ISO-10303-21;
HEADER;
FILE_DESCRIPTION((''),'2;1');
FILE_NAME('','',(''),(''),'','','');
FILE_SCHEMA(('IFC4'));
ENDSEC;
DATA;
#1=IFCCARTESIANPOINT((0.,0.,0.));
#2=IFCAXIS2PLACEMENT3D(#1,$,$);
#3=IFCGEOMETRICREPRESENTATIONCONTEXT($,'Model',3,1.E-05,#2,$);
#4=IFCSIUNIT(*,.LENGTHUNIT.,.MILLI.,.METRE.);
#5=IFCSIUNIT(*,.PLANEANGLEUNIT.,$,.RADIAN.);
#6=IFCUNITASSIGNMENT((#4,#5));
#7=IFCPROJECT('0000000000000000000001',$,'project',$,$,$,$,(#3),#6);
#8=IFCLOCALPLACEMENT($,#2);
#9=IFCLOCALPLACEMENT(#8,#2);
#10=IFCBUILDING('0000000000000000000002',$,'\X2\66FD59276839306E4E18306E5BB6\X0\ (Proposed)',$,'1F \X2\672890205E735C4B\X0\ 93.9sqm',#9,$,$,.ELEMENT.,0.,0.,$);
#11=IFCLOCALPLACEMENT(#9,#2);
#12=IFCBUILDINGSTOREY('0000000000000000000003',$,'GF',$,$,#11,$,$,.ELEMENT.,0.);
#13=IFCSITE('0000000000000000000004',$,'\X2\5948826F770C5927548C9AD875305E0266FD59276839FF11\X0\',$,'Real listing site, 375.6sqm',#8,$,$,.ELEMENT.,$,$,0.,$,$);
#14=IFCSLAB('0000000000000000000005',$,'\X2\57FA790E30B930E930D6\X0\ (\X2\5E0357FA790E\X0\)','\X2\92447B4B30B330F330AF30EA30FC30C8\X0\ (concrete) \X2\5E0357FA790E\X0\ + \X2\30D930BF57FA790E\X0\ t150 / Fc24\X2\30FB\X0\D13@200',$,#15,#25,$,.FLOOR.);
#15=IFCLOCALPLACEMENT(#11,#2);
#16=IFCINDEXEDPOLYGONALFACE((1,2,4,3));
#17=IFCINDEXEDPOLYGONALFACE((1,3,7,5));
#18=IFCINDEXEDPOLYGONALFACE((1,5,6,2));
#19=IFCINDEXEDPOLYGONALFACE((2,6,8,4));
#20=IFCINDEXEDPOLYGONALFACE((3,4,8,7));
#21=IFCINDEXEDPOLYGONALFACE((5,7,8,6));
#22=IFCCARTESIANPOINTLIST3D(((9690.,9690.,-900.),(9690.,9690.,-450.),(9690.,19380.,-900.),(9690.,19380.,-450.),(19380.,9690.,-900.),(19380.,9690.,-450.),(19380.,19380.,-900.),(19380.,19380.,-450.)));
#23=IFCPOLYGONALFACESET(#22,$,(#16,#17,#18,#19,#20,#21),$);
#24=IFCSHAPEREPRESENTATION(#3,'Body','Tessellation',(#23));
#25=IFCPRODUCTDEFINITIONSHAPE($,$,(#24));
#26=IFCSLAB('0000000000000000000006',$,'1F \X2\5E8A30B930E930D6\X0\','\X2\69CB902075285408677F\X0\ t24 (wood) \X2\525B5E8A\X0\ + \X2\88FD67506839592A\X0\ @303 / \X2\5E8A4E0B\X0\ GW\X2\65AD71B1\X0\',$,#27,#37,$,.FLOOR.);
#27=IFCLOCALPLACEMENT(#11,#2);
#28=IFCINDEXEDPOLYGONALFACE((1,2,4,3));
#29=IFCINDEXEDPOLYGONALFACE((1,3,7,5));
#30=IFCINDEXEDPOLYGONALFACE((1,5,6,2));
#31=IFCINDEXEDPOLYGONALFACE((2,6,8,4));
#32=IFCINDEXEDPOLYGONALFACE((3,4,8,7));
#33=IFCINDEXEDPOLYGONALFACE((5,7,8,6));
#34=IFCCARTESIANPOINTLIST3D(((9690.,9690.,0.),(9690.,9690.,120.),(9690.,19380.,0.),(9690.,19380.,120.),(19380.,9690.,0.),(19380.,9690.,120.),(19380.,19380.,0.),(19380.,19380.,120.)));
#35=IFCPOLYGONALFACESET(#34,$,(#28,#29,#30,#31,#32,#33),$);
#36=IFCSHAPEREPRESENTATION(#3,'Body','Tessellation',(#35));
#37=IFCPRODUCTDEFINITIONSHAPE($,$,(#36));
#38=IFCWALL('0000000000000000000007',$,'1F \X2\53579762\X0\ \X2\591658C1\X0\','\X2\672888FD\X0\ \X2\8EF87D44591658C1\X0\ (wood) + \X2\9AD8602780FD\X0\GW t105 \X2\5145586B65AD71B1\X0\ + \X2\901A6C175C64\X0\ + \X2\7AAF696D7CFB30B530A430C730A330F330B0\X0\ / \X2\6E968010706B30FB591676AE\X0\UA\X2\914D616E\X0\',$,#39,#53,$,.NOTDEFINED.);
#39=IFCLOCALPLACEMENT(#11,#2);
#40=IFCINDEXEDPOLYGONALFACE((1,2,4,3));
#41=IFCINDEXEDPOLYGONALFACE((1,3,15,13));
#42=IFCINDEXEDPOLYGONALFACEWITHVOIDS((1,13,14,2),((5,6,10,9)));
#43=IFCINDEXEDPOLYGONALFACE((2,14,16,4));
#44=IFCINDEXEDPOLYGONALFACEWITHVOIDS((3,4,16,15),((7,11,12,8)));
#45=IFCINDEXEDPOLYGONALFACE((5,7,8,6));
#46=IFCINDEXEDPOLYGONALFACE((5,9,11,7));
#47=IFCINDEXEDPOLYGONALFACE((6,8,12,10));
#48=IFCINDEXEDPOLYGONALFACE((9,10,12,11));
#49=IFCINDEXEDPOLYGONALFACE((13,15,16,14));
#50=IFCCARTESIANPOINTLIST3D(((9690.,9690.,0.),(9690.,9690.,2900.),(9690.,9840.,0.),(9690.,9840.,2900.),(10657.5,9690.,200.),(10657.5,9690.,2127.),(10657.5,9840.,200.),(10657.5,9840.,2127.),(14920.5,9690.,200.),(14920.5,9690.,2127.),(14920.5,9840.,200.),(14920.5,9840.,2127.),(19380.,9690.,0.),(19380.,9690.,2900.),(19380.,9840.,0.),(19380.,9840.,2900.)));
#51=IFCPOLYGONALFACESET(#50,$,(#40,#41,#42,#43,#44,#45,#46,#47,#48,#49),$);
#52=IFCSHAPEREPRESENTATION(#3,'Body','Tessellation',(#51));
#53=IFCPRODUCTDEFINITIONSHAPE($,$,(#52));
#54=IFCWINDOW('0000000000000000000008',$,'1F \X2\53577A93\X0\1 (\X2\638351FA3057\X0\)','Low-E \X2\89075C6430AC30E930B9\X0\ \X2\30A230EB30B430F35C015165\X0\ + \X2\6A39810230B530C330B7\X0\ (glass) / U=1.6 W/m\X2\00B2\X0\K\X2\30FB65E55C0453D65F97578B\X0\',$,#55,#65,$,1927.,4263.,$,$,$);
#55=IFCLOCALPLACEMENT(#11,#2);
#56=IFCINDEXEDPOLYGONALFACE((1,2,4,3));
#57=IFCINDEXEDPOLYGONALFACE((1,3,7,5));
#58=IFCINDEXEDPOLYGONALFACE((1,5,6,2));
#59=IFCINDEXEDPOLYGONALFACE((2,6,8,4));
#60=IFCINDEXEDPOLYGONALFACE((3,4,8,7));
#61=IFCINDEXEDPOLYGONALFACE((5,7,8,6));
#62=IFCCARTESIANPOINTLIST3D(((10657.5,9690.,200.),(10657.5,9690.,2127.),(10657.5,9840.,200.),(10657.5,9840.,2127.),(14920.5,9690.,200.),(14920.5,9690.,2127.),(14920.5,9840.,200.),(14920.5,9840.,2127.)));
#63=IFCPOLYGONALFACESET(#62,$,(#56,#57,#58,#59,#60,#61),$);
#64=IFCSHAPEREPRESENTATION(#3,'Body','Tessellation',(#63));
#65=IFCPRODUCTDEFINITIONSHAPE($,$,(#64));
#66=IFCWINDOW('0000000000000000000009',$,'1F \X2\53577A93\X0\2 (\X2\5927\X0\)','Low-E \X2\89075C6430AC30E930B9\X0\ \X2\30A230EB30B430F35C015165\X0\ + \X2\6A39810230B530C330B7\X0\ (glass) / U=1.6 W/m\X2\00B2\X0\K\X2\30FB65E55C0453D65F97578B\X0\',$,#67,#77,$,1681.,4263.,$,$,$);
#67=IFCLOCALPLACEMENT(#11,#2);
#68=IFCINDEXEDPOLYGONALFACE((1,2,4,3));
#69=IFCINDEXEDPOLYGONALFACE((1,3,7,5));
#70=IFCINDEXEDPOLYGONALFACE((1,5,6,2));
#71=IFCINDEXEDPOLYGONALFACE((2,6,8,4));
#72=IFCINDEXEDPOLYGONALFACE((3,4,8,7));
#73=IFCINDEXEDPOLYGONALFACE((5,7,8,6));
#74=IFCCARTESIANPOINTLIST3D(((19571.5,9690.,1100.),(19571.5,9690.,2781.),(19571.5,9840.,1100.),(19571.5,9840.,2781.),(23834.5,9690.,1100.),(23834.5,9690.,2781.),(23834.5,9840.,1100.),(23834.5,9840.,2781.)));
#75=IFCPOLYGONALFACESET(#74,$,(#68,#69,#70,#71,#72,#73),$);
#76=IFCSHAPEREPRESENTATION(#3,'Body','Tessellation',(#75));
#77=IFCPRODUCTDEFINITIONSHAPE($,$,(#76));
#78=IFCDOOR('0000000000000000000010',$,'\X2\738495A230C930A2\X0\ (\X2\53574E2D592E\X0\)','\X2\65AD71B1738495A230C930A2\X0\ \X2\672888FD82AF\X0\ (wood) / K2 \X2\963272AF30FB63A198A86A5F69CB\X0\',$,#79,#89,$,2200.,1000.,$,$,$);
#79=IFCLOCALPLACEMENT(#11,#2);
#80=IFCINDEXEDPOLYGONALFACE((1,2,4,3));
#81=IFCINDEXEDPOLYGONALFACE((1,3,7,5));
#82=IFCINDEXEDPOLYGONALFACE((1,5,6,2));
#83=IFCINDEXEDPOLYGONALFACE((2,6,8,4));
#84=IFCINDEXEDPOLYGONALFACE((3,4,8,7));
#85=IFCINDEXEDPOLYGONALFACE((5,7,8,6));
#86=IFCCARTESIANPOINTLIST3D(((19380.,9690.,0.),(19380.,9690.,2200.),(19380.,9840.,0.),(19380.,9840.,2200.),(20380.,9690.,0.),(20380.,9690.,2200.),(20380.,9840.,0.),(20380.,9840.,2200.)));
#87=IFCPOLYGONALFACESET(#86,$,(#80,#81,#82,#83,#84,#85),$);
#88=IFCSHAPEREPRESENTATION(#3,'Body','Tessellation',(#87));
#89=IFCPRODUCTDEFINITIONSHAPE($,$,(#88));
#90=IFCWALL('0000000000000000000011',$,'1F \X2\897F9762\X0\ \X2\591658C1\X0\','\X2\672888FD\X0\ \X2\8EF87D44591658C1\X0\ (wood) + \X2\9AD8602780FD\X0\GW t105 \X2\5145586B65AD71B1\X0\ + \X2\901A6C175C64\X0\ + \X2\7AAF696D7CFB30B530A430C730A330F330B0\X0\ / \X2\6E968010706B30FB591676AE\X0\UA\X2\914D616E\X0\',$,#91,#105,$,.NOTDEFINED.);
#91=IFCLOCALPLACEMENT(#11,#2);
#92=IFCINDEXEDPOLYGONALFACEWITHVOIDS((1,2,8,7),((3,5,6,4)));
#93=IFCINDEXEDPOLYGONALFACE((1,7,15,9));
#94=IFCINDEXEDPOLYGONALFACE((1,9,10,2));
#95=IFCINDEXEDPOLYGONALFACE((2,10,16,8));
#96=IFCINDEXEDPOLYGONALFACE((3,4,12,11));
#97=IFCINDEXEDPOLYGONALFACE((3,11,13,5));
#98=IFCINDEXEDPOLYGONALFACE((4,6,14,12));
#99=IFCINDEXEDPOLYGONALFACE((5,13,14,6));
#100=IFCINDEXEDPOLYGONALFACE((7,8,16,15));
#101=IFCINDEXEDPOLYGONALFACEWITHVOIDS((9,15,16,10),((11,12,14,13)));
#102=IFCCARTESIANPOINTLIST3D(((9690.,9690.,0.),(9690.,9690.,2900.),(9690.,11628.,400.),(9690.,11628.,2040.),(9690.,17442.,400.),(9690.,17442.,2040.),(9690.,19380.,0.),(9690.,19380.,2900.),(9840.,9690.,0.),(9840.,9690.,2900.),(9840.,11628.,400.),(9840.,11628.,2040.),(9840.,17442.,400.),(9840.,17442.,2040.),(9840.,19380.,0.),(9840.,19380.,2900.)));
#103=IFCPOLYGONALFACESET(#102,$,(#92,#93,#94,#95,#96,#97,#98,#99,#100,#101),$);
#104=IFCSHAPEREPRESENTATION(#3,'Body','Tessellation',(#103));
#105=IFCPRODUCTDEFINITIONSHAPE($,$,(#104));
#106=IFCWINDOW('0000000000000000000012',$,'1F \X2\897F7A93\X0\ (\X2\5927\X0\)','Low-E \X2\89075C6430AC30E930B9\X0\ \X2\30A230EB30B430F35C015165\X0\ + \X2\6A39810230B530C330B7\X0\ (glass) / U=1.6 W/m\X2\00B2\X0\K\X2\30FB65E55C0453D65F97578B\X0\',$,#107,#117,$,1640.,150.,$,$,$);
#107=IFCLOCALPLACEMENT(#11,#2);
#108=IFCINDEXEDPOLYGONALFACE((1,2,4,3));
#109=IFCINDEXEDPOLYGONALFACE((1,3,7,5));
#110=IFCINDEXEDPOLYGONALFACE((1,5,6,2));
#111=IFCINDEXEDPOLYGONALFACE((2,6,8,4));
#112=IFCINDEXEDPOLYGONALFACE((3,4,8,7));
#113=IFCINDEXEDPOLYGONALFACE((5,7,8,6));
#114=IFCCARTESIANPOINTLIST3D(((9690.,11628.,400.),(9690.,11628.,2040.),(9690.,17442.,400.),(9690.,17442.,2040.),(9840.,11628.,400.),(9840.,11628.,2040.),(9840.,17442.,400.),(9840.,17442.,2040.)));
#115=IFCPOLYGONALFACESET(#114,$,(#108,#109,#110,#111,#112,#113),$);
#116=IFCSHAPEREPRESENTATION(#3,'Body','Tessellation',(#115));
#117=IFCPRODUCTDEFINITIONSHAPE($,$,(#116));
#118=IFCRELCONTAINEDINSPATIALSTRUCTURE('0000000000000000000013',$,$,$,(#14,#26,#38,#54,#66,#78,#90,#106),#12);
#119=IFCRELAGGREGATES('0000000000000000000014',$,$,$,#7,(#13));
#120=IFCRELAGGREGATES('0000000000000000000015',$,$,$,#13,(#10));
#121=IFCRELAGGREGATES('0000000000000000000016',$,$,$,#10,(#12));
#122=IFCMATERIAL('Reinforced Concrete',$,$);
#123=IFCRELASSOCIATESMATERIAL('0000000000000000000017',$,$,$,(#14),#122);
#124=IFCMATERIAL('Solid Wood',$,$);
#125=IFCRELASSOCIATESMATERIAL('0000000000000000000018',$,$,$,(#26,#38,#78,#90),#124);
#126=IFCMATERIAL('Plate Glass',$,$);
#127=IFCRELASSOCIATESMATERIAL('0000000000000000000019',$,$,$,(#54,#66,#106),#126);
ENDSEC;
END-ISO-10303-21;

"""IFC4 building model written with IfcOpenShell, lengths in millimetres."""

from ifc_helpers import new_model, si_unit, frame, frame_2d, origin, place, context, project, spatial, rectangle, extrude, material, element, fill, save


model = new_model("IFC4")

# Units and contexts
model_context = context("Model", 3, precision=1e-05, world=origin())
ifc_project = project(units=[si_unit("LENGTHUNIT", "METRE", prefix="MILLI"), si_unit("PLANEANGLEUNIT", "RADIAN")], contexts=[model_context])

# Site, building, storey
site_placement = place(None, origin())
site = spatial("IfcSite", under=ifc_project, at=site_placement, Name="奈良県大和高田市曽大根１", ObjectType="Real listing site, 375.6sqm", CompositionType="ELEMENT", RefElevation=0.0)
building_placement = place(site_placement, origin())
building = spatial("IfcBuilding", under=site, at=building_placement, Name="曽大根の丘の家 (Proposed)", ObjectType="1F 木造平屋 93.9sqm", CompositionType="ELEMENT", ElevationOfRefHeight=0.0, ElevationOfTerrain=0.0)
storey_placement = place(building_placement, origin())
storey = spatial("IfcBuildingStorey", under=building, at=storey_placement, Name="GF", CompositionType="ELEMENT", Elevation=0.0)

# Slabs
ifc_material_1 = material(Name="Reinforced Concrete")
slab_1_placement = place(storey_placement, frame((4845.0, 4845.0, -450.0)))
element("IfcSlab", 1, at=slab_1_placement, inside=storey, material=ifc_material_1, Name="基礎スラブ (布基礎)", Description="鉄筋コンクリート (concrete) 布基礎 + ベタ基礎 t150 / Fc24・D13@200", PredefinedType="FLOOR", context=model_context, shape_type="SweptSolid", body=[
    extrude(rectangle(XDim=9690.0, YDim=9690.0, at=frame_2d((4845.0, 4845.0))), frame((4845.0, 4845.0, -450.0)), (0.0, 0.0, 1.0), 450.0),
])
ifc_material_2 = material(Name="Solid Wood")
slab_2_placement = place(storey_placement, frame((4845.0, 4845.0, 0.0)))
element("IfcSlab", 2, at=slab_2_placement, inside=storey, material=ifc_material_2, Name="1F 床スラブ", Description="構造用合板 t24 (wood) 剛床 + 製材根太 @303 / 床下 GW断熱", PredefinedType="FLOOR", context=model_context, shape_type="SweptSolid", body=[
    extrude(rectangle(XDim=9690.0, YDim=9690.0, at=frame_2d((4845.0, 4845.0))), frame((4845.0, 4845.0, 0.0)), (0.0, 0.0, 1.0), 120.0),
])

# Wall, openings, windows, door
wall_1_placement = place(storey_placement, frame((4845.0, 4845.0, 0.0)))
wall_1 = element("IfcWall", 3, at=wall_1_placement, inside=storey, material=ifc_material_2, Name="1F 南面 外壁", Description="木製 軸組外壁 (wood) + 高性能GW t105 充填断熱 + 通気層 + 窯業系サイディング / 準耐火・外皮UA配慮", PredefinedType="NOTDEFINED", context=model_context, shape_type="SweptSolid", body=[
    extrude(rectangle(XDim=9690.0, YDim=150.0, at=frame_2d((4845.0, 75.0))), frame((4845.0, 4845.0, 0.0)), (0.0, 0.0, 1.0), 2900.0),
])
opening_1_placement = place(storey_placement, frame((5329.0, 4845.0, 100.0)))
opening_1 = element("IfcOpeningElement", 4, at=opening_1_placement, cuts=wall_1, PredefinedType="NOTDEFINED", context=model_context, shape_type="SweptSolid", body=[
    extrude(rectangle(XDim=4263.0, YDim=150.0, at=frame_2d((2131.0, 75.0))), frame((5329.0, 4845.0, 100.0)), (0.0, 0.0, 1.0), 1927.0),
])
opening_2_placement = place(storey_placement, frame((9786.0, 4845.0, 550.0)))
opening_2 = element("IfcOpeningElement", 5, at=opening_2_placement, cuts=wall_1, PredefinedType="NOTDEFINED", context=model_context, shape_type="SweptSolid", body=[
    extrude(rectangle(XDim=4263.0, YDim=150.0, at=frame_2d((2131.0, 75.0))), frame((9786.0, 4845.0, 550.0)), (0.0, 0.0, 1.0), 1681.0),
])
opening_3_placement = place(storey_placement, frame((9690.0, 4845.0, 0.0)))
opening_3 = element("IfcOpeningElement", 6, at=opening_3_placement, cuts=wall_1, PredefinedType="NOTDEFINED", context=model_context, shape_type="SweptSolid", body=[
    extrude(rectangle(XDim=1000.0, YDim=150.0, at=frame_2d((500.0, 75.0))), frame((9690.0, 4845.0, 0.0)), (0.0, 0.0, 1.0), 2200.0),
])
ifc_material_3 = material(Name="Plate Glass")
window_1_placement = place(storey_placement, frame((5329.0, 4845.0, 100.0)))
window_1 = element("IfcWindow", 7, at=window_1_placement, inside=storey, material=ifc_material_3, Name="1F 南窓1 (掃出し)", Description="Low-E 複層ガラス アルゴン封入 + 樹脂サッシ (glass) / U=1.6 W/m²K・日射取得型", OverallHeight=1927.0, OverallWidth=4263.0, context=model_context, shape_type="SweptSolid", body=[
    extrude(rectangle(XDim=4263.0, YDim=150.0, at=frame_2d((2131.0, 75.0))), frame((5329.0, 4845.0, 100.0)), (0.0, 0.0, 1.0), 1927.0),
])
fill(opening_1, window_1)
window_2_placement = place(storey_placement, frame((9786.0, 4845.0, 550.0)))
window_2 = element("IfcWindow", 8, at=window_2_placement, inside=storey, material=ifc_material_3, Name="1F 南窓2 (大)", Description="Low-E 複層ガラス アルゴン封入 + 樹脂サッシ (glass) / U=1.6 W/m²K・日射取得型", OverallHeight=1681.0, OverallWidth=4263.0, context=model_context, shape_type="SweptSolid", body=[
    extrude(rectangle(XDim=4263.0, YDim=150.0, at=frame_2d((2131.0, 75.0))), frame((9786.0, 4845.0, 550.0)), (0.0, 0.0, 1.0), 1681.0),
])
fill(opening_2, window_2)
door_placement = place(storey_placement, frame((9690.0, 4845.0, 0.0)))
door = element("IfcDoor", 9, at=door_placement, inside=storey, material=ifc_material_2, Name="玄関ドア (南中央)", Description="断熱玄関ドア 木製芯 (wood) / K2 防犯・採風機構", OverallHeight=2200.0, OverallWidth=1000.0, context=model_context, shape_type="SweptSolid", body=[
    extrude(rectangle(XDim=1000.0, YDim=150.0, at=frame_2d((500.0, 75.0))), frame((9690.0, 4845.0, 0.0)), (0.0, 0.0, 1.0), 2200.0),
])
fill(opening_3, door)

# Wall, opening, window
wall_2_placement = place(storey_placement, frame((4845.0, 4845.0, 0.0)))
wall_2 = element("IfcWall", 10, at=wall_2_placement, inside=storey, material=ifc_material_2, Name="1F 西面 外壁", Description="木製 軸組外壁 (wood) + 高性能GW t105 充填断熱 + 通気層 + 窯業系サイディング / 準耐火・外皮UA配慮", PredefinedType="NOTDEFINED", context=model_context, shape_type="SweptSolid", body=[
    extrude(rectangle(XDim=150.0, YDim=9690.0, at=frame_2d((75.0, 4845.0))), frame((4845.0, 4845.0, 0.0)), (0.0, 0.0, 1.0), 2900.0),
])
opening_4_placement = place(storey_placement, frame((4845.0, 5814.0, 200.0)))
opening_4 = element("IfcOpeningElement", 11, at=opening_4_placement, cuts=wall_2, PredefinedType="NOTDEFINED", context=model_context, shape_type="SweptSolid", body=[
    extrude(rectangle(XDim=150.0, YDim=5814.0, at=frame_2d((75.0, 2907.0))), frame((4845.0, 5814.0, 200.0)), (0.0, 0.0, 1.0), 1640.0),
])
window_3_placement = place(storey_placement, frame((4845.0, 5814.0, 200.0)))
window_3 = element("IfcWindow", 12, at=window_3_placement, inside=storey, material=ifc_material_3, Name="1F 西窓 (大)", Description="Low-E 複層ガラス アルゴン封入 + 樹脂サッシ (glass) / U=1.6 W/m²K・日射取得型", OverallHeight=1640.0, OverallWidth=150.0, context=model_context, shape_type="SweptSolid", body=[
    extrude(rectangle(XDim=150.0, YDim=5814.0, at=frame_2d((75.0, 2907.0))), frame((4845.0, 5814.0, 200.0)), (0.0, 0.0, 1.0), 1640.0),
])
fill(opening_4, window_3)

save(model, "model.ifc")
